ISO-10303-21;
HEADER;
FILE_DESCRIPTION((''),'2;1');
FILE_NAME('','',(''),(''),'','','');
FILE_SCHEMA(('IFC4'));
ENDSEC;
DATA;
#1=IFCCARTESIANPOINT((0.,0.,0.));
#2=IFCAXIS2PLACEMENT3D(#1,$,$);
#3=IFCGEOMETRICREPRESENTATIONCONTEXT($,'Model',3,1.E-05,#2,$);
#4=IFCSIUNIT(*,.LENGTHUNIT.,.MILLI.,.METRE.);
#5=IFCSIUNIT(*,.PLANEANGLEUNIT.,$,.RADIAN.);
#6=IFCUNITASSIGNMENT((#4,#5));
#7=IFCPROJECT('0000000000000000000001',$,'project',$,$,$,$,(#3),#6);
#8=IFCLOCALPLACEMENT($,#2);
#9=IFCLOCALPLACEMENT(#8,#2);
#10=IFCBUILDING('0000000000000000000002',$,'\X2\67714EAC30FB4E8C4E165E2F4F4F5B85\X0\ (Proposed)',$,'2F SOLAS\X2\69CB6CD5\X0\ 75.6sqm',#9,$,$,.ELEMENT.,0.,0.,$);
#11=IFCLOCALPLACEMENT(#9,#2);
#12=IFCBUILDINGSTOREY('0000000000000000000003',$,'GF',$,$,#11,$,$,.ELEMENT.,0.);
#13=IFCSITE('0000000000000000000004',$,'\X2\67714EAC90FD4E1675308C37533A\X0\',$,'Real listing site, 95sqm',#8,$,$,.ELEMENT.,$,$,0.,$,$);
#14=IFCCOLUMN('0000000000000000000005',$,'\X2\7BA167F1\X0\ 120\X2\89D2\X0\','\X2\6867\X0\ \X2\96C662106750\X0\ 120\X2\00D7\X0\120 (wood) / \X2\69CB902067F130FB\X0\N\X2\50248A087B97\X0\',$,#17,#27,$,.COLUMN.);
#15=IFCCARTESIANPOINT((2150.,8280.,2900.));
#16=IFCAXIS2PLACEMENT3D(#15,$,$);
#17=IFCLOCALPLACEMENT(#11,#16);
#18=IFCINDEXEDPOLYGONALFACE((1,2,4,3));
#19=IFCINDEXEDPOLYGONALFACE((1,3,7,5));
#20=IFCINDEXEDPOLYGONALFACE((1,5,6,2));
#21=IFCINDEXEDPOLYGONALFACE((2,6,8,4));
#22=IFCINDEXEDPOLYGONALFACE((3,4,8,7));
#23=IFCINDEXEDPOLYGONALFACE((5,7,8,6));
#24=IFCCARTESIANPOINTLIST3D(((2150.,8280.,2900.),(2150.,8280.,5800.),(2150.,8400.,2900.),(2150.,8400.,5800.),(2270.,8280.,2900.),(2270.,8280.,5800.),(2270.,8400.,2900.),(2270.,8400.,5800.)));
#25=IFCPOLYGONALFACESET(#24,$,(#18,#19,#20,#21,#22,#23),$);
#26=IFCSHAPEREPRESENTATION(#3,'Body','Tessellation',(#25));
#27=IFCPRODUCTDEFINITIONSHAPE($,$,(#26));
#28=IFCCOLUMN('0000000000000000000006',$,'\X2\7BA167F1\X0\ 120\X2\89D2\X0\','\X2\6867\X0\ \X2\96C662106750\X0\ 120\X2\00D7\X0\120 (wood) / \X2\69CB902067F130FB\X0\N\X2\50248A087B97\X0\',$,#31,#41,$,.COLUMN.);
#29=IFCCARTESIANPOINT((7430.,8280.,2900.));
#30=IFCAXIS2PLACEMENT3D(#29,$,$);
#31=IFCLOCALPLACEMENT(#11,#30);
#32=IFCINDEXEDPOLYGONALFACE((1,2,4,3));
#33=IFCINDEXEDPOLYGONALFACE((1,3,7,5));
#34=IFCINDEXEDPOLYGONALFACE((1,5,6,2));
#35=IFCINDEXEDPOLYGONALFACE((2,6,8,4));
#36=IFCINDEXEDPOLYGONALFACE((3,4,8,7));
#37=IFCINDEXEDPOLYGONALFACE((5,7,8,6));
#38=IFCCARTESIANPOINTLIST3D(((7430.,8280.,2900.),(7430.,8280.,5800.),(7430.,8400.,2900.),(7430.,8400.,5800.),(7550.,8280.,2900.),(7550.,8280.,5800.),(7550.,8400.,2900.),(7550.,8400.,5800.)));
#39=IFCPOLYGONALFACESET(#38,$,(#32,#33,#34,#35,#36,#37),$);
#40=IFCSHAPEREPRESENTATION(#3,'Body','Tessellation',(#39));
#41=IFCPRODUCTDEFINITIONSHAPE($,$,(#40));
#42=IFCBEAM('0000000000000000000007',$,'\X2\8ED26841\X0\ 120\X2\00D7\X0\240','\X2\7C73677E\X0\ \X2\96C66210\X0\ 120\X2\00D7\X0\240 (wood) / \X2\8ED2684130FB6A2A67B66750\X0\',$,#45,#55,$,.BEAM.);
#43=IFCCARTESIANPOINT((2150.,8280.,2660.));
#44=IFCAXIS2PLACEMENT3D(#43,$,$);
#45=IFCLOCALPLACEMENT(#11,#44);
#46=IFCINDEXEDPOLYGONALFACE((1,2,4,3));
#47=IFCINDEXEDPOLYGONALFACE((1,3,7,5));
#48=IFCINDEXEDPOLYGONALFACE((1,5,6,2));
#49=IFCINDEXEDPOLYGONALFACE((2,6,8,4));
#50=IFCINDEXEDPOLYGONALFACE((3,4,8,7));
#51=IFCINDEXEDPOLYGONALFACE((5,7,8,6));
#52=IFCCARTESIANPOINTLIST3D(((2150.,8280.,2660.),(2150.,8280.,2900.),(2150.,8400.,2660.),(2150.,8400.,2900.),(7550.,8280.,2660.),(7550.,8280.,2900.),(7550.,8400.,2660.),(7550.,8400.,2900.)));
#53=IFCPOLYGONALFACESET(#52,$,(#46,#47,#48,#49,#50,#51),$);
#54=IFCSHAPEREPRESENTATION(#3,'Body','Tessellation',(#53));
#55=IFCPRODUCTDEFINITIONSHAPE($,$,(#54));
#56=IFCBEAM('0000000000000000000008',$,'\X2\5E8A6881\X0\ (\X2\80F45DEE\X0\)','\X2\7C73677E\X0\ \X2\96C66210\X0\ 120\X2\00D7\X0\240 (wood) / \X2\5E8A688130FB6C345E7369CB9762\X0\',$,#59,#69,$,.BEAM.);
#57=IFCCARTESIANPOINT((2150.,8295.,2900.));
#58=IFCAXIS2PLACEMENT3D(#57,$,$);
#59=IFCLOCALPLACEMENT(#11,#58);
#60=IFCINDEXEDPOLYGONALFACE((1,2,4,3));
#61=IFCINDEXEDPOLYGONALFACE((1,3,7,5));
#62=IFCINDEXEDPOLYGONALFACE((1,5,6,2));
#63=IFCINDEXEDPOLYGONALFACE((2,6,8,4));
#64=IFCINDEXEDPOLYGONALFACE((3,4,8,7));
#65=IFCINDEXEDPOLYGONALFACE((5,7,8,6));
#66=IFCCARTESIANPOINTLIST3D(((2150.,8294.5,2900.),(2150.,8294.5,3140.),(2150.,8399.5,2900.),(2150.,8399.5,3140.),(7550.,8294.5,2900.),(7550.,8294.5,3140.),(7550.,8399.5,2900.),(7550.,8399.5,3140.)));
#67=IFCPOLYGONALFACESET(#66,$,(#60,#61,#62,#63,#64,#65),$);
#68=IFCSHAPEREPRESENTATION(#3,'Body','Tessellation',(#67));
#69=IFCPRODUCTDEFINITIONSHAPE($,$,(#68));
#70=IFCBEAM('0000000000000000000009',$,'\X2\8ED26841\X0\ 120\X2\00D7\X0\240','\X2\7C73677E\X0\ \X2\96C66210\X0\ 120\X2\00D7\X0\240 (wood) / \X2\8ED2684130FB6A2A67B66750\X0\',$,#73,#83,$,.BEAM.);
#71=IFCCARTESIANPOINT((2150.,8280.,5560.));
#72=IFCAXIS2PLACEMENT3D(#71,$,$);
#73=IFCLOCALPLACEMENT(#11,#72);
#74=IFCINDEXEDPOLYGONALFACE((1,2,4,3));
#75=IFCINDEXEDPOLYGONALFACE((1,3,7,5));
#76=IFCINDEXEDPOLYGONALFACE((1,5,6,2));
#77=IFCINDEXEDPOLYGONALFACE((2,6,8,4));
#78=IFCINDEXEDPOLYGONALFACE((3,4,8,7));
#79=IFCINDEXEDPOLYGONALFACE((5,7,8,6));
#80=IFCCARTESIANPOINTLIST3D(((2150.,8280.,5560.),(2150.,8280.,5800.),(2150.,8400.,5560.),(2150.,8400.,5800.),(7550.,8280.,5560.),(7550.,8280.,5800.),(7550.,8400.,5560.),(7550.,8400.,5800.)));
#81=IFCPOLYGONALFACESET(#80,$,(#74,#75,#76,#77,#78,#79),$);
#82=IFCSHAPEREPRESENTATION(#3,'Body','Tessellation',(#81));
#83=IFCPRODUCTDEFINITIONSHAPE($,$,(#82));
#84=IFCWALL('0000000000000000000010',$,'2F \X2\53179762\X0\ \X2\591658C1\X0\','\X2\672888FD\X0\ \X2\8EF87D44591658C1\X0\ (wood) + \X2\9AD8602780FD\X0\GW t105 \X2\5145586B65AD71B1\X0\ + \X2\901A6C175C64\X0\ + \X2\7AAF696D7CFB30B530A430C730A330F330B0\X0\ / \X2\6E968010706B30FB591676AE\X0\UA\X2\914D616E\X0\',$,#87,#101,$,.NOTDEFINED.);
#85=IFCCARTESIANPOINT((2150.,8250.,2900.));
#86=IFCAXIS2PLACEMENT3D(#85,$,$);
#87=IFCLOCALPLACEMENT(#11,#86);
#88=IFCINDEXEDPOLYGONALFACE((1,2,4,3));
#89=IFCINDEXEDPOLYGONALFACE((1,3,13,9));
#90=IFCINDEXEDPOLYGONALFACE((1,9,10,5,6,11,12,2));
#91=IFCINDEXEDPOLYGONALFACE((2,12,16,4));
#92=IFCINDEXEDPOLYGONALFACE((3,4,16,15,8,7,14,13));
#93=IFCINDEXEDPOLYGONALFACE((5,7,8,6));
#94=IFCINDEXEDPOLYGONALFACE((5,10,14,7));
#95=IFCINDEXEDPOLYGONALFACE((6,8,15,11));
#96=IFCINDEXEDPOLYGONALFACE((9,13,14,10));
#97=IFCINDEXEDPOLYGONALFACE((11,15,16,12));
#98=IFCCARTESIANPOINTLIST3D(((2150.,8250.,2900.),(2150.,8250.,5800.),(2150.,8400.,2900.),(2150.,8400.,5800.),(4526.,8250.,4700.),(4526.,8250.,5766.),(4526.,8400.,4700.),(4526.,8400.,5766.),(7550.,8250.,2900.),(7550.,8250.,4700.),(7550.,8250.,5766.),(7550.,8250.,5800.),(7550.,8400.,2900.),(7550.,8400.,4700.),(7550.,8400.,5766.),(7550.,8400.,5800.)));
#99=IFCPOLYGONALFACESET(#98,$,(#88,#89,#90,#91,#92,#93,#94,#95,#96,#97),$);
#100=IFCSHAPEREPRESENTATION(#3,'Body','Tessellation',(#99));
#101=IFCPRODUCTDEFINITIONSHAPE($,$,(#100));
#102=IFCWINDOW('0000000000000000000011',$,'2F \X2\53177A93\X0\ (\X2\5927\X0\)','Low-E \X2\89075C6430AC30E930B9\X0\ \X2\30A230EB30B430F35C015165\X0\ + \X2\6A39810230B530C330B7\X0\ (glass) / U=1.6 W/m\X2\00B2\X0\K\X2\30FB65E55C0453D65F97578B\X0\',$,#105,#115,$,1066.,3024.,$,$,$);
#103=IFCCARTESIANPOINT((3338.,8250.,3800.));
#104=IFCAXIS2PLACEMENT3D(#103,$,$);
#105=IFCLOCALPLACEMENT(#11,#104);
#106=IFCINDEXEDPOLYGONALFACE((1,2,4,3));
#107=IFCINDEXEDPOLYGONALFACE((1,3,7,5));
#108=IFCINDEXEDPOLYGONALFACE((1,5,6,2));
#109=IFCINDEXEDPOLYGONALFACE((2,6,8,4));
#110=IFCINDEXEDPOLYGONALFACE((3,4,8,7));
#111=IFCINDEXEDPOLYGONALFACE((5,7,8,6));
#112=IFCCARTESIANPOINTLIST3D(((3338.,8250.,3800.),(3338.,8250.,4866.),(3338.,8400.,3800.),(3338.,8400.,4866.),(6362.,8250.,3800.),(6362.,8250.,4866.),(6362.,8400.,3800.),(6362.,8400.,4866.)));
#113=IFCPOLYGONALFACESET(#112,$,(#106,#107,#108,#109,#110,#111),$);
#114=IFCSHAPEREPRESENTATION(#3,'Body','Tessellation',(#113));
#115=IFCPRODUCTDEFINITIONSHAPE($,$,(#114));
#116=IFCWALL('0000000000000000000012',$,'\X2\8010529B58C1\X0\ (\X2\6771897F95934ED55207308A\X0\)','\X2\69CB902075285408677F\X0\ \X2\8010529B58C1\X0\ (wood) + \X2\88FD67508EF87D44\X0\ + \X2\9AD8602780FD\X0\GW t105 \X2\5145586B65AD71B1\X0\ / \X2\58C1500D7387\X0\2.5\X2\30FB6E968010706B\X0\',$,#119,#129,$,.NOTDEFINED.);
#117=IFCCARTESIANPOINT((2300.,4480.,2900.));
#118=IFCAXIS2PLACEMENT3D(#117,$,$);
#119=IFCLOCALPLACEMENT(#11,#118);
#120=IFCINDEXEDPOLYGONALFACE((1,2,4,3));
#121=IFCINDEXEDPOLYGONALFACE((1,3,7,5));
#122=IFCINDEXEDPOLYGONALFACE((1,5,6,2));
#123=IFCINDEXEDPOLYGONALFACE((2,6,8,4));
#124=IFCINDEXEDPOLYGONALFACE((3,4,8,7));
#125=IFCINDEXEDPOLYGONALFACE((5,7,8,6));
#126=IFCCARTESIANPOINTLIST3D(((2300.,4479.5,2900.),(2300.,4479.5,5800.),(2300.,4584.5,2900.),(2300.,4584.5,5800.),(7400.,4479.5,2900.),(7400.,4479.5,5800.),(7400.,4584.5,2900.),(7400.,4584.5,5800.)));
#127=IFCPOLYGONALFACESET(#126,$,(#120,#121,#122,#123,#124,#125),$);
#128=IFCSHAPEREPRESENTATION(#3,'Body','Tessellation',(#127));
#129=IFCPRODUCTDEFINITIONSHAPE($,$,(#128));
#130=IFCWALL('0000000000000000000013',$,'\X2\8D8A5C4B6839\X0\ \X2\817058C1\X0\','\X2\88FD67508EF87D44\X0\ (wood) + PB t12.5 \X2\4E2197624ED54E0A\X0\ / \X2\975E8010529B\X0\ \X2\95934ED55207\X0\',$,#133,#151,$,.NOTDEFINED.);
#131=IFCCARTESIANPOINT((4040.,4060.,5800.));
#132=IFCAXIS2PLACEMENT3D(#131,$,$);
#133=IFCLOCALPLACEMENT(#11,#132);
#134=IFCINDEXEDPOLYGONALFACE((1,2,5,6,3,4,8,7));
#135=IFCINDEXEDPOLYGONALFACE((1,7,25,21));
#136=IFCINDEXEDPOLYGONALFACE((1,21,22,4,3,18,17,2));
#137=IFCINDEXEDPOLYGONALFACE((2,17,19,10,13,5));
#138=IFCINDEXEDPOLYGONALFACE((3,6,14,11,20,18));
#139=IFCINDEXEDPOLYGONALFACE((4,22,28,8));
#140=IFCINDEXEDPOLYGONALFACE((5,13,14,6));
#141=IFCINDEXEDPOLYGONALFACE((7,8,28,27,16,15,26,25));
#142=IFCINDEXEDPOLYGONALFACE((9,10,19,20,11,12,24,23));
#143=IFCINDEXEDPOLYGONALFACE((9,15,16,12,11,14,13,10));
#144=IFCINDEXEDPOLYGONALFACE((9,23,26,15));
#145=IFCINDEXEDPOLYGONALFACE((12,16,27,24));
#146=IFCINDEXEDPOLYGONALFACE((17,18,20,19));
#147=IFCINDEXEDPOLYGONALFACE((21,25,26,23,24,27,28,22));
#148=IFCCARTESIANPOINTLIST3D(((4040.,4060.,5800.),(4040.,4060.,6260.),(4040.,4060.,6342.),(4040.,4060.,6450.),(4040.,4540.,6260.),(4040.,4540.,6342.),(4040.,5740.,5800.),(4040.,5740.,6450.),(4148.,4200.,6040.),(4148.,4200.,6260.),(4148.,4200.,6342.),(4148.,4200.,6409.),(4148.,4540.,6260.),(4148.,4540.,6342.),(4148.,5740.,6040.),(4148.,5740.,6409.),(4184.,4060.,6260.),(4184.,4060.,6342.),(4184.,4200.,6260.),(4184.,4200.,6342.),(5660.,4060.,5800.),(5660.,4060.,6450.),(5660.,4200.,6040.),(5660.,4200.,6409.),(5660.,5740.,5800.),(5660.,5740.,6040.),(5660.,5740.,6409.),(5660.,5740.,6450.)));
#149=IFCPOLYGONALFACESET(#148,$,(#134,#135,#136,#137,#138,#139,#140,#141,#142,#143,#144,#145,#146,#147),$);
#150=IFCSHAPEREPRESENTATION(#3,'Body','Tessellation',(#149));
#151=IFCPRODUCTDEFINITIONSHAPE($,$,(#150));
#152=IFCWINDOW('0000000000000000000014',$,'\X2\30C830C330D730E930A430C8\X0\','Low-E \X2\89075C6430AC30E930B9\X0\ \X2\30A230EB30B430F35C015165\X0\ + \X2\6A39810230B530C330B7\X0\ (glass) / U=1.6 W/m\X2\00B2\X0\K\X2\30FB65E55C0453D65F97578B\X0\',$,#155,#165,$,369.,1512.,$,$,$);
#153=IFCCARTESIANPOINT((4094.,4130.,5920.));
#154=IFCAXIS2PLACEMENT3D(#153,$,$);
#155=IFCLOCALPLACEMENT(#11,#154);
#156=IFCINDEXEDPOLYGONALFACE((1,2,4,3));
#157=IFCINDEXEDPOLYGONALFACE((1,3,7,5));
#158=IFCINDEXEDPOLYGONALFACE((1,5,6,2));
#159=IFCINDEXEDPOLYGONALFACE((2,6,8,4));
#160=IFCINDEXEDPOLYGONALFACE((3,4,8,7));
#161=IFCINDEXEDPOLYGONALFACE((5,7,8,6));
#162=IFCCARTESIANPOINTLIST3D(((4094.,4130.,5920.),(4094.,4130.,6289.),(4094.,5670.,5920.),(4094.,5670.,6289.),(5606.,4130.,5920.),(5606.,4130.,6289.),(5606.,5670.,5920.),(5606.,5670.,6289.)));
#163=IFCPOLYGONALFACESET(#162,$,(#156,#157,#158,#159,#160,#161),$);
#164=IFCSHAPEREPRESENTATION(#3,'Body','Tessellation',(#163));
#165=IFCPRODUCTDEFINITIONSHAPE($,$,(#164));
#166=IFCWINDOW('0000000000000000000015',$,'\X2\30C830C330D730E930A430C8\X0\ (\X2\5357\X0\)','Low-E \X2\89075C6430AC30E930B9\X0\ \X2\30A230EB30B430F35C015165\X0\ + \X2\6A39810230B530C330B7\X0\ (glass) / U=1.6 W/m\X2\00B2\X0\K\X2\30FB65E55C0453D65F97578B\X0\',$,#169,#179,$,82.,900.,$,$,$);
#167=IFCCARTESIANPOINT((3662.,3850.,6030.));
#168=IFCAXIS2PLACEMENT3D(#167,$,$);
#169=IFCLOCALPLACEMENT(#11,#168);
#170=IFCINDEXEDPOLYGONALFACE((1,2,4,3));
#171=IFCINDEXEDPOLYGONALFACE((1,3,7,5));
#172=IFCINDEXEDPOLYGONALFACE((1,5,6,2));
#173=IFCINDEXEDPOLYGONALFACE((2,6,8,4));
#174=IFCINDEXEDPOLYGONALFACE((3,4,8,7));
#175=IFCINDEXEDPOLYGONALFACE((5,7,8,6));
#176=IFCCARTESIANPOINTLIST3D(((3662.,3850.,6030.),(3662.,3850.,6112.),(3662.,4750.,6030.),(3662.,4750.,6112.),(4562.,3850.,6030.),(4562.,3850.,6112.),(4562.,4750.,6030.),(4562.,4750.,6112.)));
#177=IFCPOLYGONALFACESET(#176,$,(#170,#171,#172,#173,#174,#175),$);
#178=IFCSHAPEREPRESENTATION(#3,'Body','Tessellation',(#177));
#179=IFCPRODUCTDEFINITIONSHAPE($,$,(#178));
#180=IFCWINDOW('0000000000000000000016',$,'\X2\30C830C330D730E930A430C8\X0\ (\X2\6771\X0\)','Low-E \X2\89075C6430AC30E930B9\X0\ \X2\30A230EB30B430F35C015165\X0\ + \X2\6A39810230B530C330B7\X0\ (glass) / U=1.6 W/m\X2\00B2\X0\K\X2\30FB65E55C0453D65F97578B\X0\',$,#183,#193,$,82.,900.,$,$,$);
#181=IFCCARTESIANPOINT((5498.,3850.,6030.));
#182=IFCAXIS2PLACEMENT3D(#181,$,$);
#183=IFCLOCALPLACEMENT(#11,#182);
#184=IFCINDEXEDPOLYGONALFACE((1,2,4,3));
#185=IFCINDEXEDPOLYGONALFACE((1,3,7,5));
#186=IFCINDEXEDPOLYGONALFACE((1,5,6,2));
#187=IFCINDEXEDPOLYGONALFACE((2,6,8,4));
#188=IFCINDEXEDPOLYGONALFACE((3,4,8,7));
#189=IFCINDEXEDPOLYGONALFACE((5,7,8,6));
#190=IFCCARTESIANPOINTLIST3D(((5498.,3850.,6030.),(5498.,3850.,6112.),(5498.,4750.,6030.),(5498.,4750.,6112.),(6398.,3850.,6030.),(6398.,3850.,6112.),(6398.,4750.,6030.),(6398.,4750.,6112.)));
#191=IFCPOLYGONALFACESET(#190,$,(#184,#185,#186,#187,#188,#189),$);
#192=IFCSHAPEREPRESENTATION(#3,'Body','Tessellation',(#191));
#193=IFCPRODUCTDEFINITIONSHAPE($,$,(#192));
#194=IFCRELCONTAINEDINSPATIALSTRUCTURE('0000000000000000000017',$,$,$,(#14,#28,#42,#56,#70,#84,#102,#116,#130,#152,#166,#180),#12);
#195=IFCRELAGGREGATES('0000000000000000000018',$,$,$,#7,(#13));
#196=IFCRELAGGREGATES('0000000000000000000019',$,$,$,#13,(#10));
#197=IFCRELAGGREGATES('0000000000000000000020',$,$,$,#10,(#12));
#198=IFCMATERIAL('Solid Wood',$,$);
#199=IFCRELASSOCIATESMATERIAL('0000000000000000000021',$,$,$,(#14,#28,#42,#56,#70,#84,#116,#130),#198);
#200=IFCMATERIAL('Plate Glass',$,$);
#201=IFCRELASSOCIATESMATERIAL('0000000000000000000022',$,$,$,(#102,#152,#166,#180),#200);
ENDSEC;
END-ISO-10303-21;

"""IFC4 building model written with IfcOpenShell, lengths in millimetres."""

from ifc_helpers import new_model, si_unit, frame, frame_2d, origin, place, context, project, spatial, rectangle, extrude, material, element, fill, save


model = new_model("IFC4")

# Units and contexts
model_context = context("Model", 3, precision=1e-05, world=origin())
ifc_project = project(units=[si_unit("LENGTHUNIT", "METRE", prefix="MILLI"), si_unit("PLANEANGLEUNIT", "RADIAN")], contexts=[model_context])

# Site, building, storey
site_placement = place(None, origin())
site = spatial("IfcSite", under=ifc_project, at=site_placement, Name="東京都世田谷区", ObjectType="Real listing site, 95sqm", CompositionType="ELEMENT", RefElevation=0.0)
building_placement = place(site_placement, origin())
building = spatial("IfcBuilding", under=site, at=building_placement, Name="東京・二世帯住宅 (Proposed)", ObjectType="2F SOLAS構法 75.6sqm", CompositionType="ELEMENT", ElevationOfRefHeight=0.0, ElevationOfTerrain=0.0)
storey_placement = place(building_placement, origin())
storey = spatial("IfcBuildingStorey", under=building, at=storey_placement, Name="GF", CompositionType="ELEMENT", Elevation=0.0)

# Columns
ifc_material_1 = material(Name="Solid Wood")
column_1_placement = place(storey_placement, frame((2150.0, 8280.0, 2900.0)))
element("IfcColumn", 1, at=column_1_placement, inside=storey, material=ifc_material_1, Name="管柱 120角", Description="桧 集成材 120×120 (wood) / 構造柱・N値計算", PredefinedType="COLUMN", context=model_context, shape_type="SweptSolid", body=[
    extrude(rectangle(XDim=120.0, YDim=120.0, at=frame_2d((60.0, 60.0))), frame((2150.0, 8280.0, 2900.0)), (0.0, 0.0, 1.0), 2900.0),
])
column_2_placement = place(storey_placement, frame((7430.0, 8280.0, 2900.0)))
element("IfcColumn", 2, at=column_2_placement, inside=storey, material=ifc_material_1, Name="管柱 120角", Description="桧 集成材 120×120 (wood) / 構造柱・N値計算", PredefinedType="COLUMN", context=model_context, shape_type="SweptSolid", body=[
    extrude(rectangle(XDim=120.0, YDim=120.0, at=frame_2d((60.0, 60.0))), frame((7430.0, 8280.0, 2900.0)), (0.0, 0.0, 1.0), 2900.0),
])

# Beams
beam_1_placement = place(storey_placement, frame((2150.0, 8280.0, 2660.0)))
element("IfcBeam", 3, at=beam_1_placement, inside=storey, material=ifc_material_1, Name="軒桁 120×240", Description="米松 集成 120×240 (wood) / 軒桁・横架材", PredefinedType="BEAM", context=model_context, shape_type="SweptSolid", body=[
    extrude(rectangle(XDim=5400.0, YDim=120.0, at=frame_2d((2700.0, 60.0))), frame((2150.0, 8280.0, 2660.0)), (0.0, 0.0, 1.0), 240.0),
])
beam_2_placement = place(storey_placement, frame((2150.0, 8295.0, 2900.0)))
element("IfcBeam", 4, at=beam_2_placement, inside=storey, material=ifc_material_1, Name="床梁 (胴差)", Description="米松 集成 120×240 (wood) / 床梁・水平構面", PredefinedType="BEAM", context=model_context, shape_type="SweptSolid", body=[
    extrude(rectangle(XDim=5400.0, YDim=105.0, at=frame_2d((2700.0, 52.0))), frame((2150.0, 8295.0, 2900.0)), (0.0, 0.0, 1.0), 240.0),
])
beam_3_placement = place(storey_placement, frame((2150.0, 8280.0, 5560.0)))
element("IfcBeam", 5, at=beam_3_placement, inside=storey, material=ifc_material_1, Name="軒桁 120×240", Description="米松 集成 120×240 (wood) / 軒桁・横架材", PredefinedType="BEAM", context=model_context, shape_type="SweptSolid", body=[
    extrude(rectangle(XDim=5400.0, YDim=120.0, at=frame_2d((2700.0, 60.0))), frame((2150.0, 8280.0, 5560.0)), (0.0, 0.0, 1.0), 240.0),
])

# Wall, opening, window
wall_1_placement = place(storey_placement, frame((2150.0, 8250.0, 2900.0)))
wall_1 = element("IfcWall", 6, at=wall_1_placement, inside=storey, material=ifc_material_1, Name="2F 北面 外壁", Description="木製 軸組外壁 (wood) + 高性能GW t105 充填断熱 + 通気層 + 窯業系サイディング / 準耐火・外皮UA配慮", PredefinedType="NOTDEFINED", context=model_context, shape_type="SweptSolid", body=[
    extrude(rectangle(XDim=5400.0, YDim=150.0, at=frame_2d((2700.0, 75.0))), frame((2150.0, 8250.0, 2900.0)), (0.0, 0.0, 1.0), 2900.0),
])
opening_1_placement = place(storey_placement, frame((3338.0, 8250.0, 3800.0)))
opening_1 = element("IfcOpeningElement", 7, at=opening_1_placement, cuts=wall_1, PredefinedType="NOTDEFINED", context=model_context, shape_type="SweptSolid", body=[
    extrude(rectangle(XDim=3024.0, YDim=150.0, at=frame_2d((1512.0, 75.0))), frame((3338.0, 8250.0, 3800.0)), (0.0, 0.0, 1.0), 1066.0),
])
ifc_material_2 = material(Name="Plate Glass")
window_1_placement = place(storey_placement, frame((3338.0, 8250.0, 3800.0)))
window_1 = element("IfcWindow", 8, at=window_1_placement, inside=storey, material=ifc_material_2, Name="2F 北窓 (大)", Description="Low-E 複層ガラス アルゴン封入 + 樹脂サッシ (glass) / U=1.6 W/m²K・日射取得型", OverallHeight=1066.0, OverallWidth=3024.0, context=model_context, shape_type="SweptSolid", body=[
    extrude(rectangle(XDim=3024.0, YDim=150.0, at=frame_2d((1512.0, 75.0))), frame((3338.0, 8250.0, 3800.0)), (0.0, 0.0, 1.0), 1066.0),
])
fill(opening_1, window_1)

# Wall
wall_2_placement = place(storey_placement, frame((2300.0, 4480.0, 2900.0)))
element("IfcWall", 9, at=wall_2_placement, inside=storey, material=ifc_material_1, Name="耐力壁 (東西間仕切り)", Description="構造用合板 耐力壁 (wood) + 製材軸組 + 高性能GW t105 充填断熱 / 壁倍率2.5・準耐火", PredefinedType="NOTDEFINED", context=model_context, shape_type="SweptSolid", body=[
    extrude(rectangle(XDim=5100.0, YDim=105.0, at=frame_2d((2550.0, 52.0))), frame((2300.0, 4480.0, 2900.0)), (0.0, 0.0, 1.0), 2900.0),
])

# Wall, openings, windows
wall_3_placement = place(storey_placement, frame((4040.0, 4060.0, 5800.0)))
wall_3 = element("IfcWall", 10, at=wall_3_placement, inside=storey, material=ifc_material_1, Name="越屋根 腰壁", Description="製材軸組 (wood) + PB t12.5 両面仕上 / 非耐力 間仕切", PredefinedType="NOTDEFINED", context=model_context, shape_type="SweptSolid", body=[
    extrude(rectangle(XDim=1620.0, YDim=1680.0, at=frame_2d((810.0, 840.0))), frame((4040.0, 4060.0, 5800.0)), (0.0, 0.0, 1.0), 650.0),
])
opening_2_placement = place(storey_placement, frame((4094.0, 4130.0, 5920.0)))
opening_2 = element("IfcOpeningElement", 11, at=opening_2_placement, cuts=wall_3, PredefinedType="NOTDEFINED", context=model_context, shape_type="SweptSolid", body=[
    extrude(rectangle(XDim=1512.0, YDim=1540.0, at=frame_2d((756.0, 770.0))), frame((4094.0, 4130.0, 5920.0)), (0.0, 0.0, 1.0), 369.0),
])
opening_3_placement = place(storey_placement, frame((3662.0, 3850.0, 6030.0)))
opening_3 = element("IfcOpeningElement", 12, at=opening_3_placement, cuts=wall_3, PredefinedType="NOTDEFINED", context=model_context, shape_type="SweptSolid", body=[
    extrude(rectangle(XDim=900.0, YDim=900.0, at=frame_2d((450.0, 450.0))), frame((3662.0, 3850.0, 6030.0)), (0.0, 0.0, 1.0), 82.0),
])
opening_4_placement = place(storey_placement, frame((5498.0, 3850.0, 6030.0)))
opening_4 = element("IfcOpeningElement", 13, at=opening_4_placement, cuts=wall_3, PredefinedType="NOTDEFINED", context=model_context, shape_type="SweptSolid", body=[
    extrude(rectangle(XDim=900.0, YDim=900.0, at=frame_2d((450.0, 450.0))), frame((5498.0, 3850.0, 6030.0)), (0.0, 0.0, 1.0), 82.0),
])
window_2_placement = place(storey_placement, frame((4094.0, 4130.0, 5920.0)))
window_2 = element("IfcWindow", 14, at=window_2_placement, inside=storey, material=ifc_material_2, Name="トップライト", Description="Low-E 複層ガラス アルゴン封入 + 樹脂サッシ (glass) / U=1.6 W/m²K・日射取得型", OverallHeight=369.0, OverallWidth=1512.0, context=model_context, shape_type="SweptSolid", body=[
    extrude(rectangle(XDim=1512.0, YDim=1540.0, at=frame_2d((756.0, 770.0))), frame((4094.0, 4130.0, 5920.0)), (0.0, 0.0, 1.0), 369.0),
])
fill(opening_2, window_2)
window_3_placement = place(storey_placement, frame((3662.0, 3850.0, 6030.0)))
window_3 = element("IfcWindow", 15, at=window_3_placement, inside=storey, material=ifc_material_2, Name="トップライト (南)", Description="Low-E 複層ガラス アルゴン封入 + 樹脂サッシ (glass) / U=1.6 W/m²K・日射取得型", OverallHeight=82.0, OverallWidth=900.0, context=model_context, shape_type="SweptSolid", body=[
    extrude(rectangle(XDim=900.0, YDim=900.0, at=frame_2d((450.0, 450.0))), frame((3662.0, 3850.0, 6030.0)), (0.0, 0.0, 1.0), 82.0),
])
fill(opening_3, window_3)
window_4_placement = place(storey_placement, frame((5498.0, 3850.0, 6030.0)))
window_4 = element("IfcWindow", 16, at=window_4_placement, inside=storey, material=ifc_material_2, Name="トップライト (東)", Description="Low-E 複層ガラス アルゴン封入 + 樹脂サッシ (glass) / U=1.6 W/m²K・日射取得型", OverallHeight=82.0, OverallWidth=900.0, context=model_context, shape_type="SweptSolid", body=[
    extrude(rectangle(XDim=900.0, YDim=900.0, at=frame_2d((450.0, 450.0))), frame((5498.0, 3850.0, 6030.0)), (0.0, 0.0, 1.0), 82.0),
])
fill(opening_4, window_4)

save(model, "model.ifc")
